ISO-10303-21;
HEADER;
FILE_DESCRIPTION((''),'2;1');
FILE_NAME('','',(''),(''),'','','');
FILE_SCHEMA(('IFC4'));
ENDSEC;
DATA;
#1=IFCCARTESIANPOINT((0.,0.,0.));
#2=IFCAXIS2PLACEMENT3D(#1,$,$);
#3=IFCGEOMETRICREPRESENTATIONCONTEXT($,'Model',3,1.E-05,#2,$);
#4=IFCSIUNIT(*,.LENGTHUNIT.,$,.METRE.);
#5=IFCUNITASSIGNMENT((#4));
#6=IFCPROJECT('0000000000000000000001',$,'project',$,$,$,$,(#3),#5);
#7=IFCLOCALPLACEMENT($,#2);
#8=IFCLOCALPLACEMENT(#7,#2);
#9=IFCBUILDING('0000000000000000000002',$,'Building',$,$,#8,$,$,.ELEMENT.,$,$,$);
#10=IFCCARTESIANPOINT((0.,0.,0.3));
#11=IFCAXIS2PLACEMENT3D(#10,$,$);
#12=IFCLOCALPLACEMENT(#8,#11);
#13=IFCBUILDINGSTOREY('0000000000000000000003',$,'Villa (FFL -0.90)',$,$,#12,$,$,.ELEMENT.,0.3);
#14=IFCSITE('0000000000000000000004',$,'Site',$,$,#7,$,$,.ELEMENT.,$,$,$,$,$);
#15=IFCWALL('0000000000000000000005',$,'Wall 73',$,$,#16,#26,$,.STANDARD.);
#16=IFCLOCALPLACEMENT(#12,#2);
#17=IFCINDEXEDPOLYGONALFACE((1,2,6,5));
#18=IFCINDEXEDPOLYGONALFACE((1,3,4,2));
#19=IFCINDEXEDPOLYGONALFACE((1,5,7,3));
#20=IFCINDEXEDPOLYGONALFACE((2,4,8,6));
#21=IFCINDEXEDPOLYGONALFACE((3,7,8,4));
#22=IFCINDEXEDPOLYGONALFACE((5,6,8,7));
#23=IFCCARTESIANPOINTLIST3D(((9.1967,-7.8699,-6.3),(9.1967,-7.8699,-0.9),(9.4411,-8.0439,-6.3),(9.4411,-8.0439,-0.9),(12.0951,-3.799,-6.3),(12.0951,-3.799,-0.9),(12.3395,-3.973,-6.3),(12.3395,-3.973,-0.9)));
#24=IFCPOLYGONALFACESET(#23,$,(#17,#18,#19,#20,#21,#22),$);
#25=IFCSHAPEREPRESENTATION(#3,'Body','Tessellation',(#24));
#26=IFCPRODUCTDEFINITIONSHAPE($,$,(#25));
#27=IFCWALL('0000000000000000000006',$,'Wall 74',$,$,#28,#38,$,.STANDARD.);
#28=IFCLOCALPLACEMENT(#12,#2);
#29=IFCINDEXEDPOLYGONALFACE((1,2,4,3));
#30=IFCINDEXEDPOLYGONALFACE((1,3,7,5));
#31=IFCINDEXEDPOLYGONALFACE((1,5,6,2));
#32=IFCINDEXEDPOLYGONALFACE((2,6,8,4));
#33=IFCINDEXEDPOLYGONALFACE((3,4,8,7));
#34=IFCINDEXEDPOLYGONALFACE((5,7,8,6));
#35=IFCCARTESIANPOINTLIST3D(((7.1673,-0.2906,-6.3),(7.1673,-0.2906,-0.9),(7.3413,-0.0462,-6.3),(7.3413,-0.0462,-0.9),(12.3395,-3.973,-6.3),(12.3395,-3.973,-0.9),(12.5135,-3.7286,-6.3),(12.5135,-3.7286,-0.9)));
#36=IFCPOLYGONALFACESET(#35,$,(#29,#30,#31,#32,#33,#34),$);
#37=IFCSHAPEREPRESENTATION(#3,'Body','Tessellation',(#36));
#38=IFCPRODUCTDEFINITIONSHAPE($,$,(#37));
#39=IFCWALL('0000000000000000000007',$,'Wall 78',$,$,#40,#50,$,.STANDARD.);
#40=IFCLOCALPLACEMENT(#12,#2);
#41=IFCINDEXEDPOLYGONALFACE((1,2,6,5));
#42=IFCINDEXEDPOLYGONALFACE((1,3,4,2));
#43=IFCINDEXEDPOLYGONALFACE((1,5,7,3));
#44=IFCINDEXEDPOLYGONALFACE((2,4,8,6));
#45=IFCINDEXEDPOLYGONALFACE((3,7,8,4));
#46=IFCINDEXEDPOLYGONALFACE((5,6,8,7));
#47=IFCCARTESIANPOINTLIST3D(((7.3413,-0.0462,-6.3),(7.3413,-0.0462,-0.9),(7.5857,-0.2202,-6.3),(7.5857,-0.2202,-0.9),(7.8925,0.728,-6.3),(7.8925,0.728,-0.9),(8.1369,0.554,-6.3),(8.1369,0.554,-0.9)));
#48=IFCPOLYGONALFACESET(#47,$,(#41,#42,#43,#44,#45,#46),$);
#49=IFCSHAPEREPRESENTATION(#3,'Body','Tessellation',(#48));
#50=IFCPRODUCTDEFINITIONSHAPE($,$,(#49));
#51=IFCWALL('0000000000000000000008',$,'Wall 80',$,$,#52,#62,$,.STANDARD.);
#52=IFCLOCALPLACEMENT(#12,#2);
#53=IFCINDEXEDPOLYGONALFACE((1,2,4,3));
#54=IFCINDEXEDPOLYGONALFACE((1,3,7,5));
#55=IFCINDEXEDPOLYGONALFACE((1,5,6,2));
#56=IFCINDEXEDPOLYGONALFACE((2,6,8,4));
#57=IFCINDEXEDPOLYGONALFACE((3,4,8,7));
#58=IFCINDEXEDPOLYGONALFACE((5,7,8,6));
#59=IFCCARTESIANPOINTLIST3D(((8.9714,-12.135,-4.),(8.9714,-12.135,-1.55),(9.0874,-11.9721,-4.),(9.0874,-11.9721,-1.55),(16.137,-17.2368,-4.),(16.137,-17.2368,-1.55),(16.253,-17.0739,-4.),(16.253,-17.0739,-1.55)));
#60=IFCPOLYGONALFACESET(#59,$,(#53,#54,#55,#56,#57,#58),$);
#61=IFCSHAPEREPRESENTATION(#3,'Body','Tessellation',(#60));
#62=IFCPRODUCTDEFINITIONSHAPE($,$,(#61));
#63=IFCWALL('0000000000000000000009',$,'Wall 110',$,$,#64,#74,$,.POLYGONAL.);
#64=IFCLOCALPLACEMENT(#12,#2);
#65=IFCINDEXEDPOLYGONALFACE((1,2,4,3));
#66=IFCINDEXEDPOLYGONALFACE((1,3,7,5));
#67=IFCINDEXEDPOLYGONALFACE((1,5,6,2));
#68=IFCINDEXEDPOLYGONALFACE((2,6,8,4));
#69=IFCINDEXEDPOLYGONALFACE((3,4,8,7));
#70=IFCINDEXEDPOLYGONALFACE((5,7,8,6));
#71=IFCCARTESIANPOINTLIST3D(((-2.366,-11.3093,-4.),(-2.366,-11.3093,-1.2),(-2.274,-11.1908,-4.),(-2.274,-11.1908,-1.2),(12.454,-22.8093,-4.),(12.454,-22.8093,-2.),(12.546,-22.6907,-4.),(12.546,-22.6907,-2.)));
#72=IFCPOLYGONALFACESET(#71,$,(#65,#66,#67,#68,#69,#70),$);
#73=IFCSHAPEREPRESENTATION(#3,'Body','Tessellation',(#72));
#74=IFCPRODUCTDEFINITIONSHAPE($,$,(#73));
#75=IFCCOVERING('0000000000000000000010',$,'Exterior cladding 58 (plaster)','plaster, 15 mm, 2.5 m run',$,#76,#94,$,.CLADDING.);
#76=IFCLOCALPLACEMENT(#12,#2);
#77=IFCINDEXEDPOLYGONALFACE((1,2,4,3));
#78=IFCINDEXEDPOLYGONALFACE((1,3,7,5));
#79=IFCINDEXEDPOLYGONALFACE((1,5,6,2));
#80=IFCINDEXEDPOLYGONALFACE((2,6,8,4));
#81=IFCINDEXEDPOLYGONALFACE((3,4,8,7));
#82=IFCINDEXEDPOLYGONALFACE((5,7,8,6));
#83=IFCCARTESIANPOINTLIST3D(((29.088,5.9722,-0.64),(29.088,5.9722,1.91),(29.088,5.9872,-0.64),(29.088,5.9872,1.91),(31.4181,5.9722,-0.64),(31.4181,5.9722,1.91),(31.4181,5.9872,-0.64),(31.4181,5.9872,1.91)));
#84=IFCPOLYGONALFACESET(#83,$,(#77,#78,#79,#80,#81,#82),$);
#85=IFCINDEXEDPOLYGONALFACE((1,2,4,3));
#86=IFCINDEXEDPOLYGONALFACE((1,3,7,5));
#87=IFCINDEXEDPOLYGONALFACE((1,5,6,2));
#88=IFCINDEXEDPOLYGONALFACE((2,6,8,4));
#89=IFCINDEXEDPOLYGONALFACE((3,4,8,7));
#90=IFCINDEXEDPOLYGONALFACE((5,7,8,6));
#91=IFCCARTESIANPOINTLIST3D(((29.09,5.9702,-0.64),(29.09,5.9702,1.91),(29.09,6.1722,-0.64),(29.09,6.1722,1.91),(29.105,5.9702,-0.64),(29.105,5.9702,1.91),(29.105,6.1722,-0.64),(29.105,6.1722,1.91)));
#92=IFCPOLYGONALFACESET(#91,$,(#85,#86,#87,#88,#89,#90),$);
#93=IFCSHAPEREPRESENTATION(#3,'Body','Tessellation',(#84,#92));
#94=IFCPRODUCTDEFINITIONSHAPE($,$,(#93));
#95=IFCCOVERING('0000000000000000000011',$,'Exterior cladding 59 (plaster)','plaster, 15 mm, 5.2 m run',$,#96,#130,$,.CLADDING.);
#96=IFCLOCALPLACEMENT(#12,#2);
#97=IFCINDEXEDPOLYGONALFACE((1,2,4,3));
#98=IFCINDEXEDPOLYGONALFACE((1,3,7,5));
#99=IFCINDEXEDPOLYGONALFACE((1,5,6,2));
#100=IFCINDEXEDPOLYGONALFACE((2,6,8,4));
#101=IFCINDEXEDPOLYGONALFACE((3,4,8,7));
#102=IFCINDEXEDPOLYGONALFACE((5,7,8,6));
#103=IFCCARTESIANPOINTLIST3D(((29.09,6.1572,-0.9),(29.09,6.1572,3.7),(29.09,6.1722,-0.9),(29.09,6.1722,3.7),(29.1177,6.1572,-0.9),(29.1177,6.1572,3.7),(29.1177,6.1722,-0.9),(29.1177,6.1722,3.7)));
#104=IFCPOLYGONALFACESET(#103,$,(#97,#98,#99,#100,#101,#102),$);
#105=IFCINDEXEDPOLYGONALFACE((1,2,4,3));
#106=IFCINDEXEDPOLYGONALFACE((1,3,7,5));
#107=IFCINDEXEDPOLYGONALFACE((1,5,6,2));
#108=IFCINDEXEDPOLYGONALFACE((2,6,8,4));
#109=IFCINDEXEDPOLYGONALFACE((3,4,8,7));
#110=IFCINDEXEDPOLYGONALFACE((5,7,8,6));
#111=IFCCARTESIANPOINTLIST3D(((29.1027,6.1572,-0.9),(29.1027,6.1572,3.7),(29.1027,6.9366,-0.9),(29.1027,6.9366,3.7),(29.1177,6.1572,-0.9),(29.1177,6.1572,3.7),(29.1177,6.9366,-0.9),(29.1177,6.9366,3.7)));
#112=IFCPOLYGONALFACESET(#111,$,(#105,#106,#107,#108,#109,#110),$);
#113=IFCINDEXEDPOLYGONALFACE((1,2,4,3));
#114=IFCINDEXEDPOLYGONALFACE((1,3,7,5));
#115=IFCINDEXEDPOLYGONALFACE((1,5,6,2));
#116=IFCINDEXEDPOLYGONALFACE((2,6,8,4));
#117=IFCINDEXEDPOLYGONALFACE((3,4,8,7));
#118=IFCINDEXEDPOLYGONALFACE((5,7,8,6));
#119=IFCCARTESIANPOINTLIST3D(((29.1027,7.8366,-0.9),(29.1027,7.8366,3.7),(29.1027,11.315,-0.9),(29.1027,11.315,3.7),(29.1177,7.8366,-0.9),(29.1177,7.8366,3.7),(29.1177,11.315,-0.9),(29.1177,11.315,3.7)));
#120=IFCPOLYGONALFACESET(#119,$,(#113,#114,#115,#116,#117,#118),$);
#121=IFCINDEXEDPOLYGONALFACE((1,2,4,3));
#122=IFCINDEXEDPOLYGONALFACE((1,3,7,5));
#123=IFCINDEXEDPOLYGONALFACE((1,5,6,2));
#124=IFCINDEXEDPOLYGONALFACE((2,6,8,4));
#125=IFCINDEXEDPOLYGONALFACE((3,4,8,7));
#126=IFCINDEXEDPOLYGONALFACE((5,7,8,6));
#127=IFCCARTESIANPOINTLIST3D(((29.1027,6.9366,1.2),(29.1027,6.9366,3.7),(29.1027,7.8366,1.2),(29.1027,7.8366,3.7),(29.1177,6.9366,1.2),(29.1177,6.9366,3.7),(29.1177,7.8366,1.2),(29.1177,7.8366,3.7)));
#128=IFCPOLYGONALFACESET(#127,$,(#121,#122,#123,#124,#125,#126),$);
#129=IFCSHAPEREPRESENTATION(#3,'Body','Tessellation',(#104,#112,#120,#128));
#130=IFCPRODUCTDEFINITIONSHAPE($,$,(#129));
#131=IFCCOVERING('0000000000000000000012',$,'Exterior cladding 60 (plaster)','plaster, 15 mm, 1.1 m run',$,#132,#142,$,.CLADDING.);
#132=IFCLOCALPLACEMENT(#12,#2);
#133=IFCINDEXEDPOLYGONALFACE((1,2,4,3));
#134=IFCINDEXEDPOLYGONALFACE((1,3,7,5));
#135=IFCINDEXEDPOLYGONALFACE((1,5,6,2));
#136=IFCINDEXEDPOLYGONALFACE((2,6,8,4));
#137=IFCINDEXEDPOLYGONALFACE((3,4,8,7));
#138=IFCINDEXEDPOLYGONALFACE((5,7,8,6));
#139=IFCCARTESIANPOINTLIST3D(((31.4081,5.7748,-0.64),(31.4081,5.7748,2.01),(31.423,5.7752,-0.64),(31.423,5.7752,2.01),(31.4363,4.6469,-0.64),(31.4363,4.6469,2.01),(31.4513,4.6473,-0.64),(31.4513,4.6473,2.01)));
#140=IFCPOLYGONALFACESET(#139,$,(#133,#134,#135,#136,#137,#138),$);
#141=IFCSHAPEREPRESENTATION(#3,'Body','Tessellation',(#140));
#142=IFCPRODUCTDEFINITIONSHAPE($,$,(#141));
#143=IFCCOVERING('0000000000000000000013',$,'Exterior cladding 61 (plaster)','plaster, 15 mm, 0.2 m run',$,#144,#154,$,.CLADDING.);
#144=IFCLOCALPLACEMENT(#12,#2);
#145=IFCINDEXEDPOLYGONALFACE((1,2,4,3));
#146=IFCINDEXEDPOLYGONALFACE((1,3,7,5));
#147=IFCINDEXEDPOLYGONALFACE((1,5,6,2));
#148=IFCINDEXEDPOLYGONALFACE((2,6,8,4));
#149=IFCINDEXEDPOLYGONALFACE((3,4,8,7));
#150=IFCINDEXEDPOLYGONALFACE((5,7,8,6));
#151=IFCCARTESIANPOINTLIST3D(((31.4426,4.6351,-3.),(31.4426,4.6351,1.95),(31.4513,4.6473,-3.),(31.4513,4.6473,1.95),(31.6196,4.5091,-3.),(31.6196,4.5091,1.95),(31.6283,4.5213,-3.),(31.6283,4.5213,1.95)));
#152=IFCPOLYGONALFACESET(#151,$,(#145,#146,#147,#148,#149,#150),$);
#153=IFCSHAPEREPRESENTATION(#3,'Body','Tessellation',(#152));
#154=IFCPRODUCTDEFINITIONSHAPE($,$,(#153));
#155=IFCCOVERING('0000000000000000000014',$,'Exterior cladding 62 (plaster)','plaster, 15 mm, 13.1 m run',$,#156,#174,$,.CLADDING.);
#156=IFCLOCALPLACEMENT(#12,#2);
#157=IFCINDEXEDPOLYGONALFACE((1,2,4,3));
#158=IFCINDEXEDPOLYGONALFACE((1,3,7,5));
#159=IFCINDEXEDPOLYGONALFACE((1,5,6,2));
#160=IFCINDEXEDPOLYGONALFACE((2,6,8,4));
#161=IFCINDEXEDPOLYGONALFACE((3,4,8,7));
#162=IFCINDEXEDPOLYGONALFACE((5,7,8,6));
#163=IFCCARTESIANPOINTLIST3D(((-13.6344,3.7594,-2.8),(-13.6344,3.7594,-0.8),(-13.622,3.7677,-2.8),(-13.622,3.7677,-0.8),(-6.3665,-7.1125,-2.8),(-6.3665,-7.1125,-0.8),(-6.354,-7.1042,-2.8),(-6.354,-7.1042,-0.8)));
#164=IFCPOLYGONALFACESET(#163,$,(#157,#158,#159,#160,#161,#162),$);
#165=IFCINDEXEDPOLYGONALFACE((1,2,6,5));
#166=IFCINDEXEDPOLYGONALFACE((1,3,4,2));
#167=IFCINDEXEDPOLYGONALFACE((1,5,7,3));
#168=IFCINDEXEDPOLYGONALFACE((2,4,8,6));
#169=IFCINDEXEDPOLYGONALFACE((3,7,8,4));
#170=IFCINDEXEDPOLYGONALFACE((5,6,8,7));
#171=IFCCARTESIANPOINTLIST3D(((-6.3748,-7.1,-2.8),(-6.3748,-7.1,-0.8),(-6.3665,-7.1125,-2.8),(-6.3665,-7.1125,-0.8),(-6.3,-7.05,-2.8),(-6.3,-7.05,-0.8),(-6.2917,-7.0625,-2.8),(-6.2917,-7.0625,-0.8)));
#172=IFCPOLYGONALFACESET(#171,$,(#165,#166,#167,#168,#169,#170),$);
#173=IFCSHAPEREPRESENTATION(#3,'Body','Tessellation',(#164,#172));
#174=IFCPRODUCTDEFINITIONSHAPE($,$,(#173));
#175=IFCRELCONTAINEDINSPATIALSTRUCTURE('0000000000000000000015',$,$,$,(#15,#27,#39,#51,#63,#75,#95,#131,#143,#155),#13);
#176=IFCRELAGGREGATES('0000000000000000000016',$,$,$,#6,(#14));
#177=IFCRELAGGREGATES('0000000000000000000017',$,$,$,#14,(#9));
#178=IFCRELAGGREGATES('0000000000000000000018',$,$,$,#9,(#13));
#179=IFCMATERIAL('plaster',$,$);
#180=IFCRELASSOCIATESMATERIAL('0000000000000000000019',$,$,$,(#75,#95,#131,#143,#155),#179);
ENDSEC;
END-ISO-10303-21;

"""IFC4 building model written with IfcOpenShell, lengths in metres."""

from ifc_helpers import new_model, si_unit, frame, frame_2d, origin, origin_with_axes, place, context, project, spatial, polyline, rectangle, outline, extrude, material, element, save


model = new_model("IFC4")

# Units and contexts
model_context = context("Model", 3, precision=1e-05, world=origin())
ifc_project = project(units=[si_unit("LENGTHUNIT", "METRE")], contexts=[model_context])

# Site, building, storey
site_placement = place(None, origin())
site = spatial("IfcSite", under=ifc_project, at=site_placement, Name="Site", CompositionType="ELEMENT")
building_placement = place(site_placement, origin())
building = spatial("IfcBuilding", under=site, at=building_placement, Name="Building", CompositionType="ELEMENT")
storey_placement = place(building_placement, frame((0.0, 0.0, 0.3)))
storey = spatial("IfcBuildingStorey", under=building, at=storey_placement, Name="Villa (FFL -0.90)", CompositionType="ELEMENT", Elevation=0.3)

# Walls
wall_1_placement = place(storey_placement, frame((9.3189, -7.9569, -6.3), z_axis=(0.0, 0.0, 1.0), x_axis=(0.579992, 0.814622, 0.0)))
element("IfcWall", 1, at=wall_1_placement, inside=storey, Name="Wall 73", PredefinedType="STANDARD", context=model_context, shape_type="SweptSolid", body=[
    extrude(rectangle(XDim=4.9973, YDim=0.3, at=frame_2d((2.4986, 0.0))), origin(), (0.0, 0.0, 1.0), 5.4),
])
wall_2_placement = place(storey_placement, frame((7.2543, -0.1684, -6.3), z_axis=(0.0, 0.0, 1.0), x_axis=(0.814622, -0.579992, 0.0)))
element("IfcWall", 2, at=wall_2_placement, inside=storey, Name="Wall 74", PredefinedType="STANDARD", context=model_context, shape_type="SweptSolid", body=[
    extrude(rectangle(XDim=6.3491, YDim=0.3, at=frame_2d((3.1746, 0.0))), origin(), (0.0, 0.0, 1.0), 5.4),
])
wall_3_placement = place(storey_placement, frame((7.4635, -0.1332, -6.3), z_axis=(0.0, 0.0, 1.0), x_axis=(0.579992, 0.814622, 0.0)))
element("IfcWall", 3, at=wall_3_placement, inside=storey, Name="Wall 78", PredefinedType="STANDARD", context=model_context, shape_type="SweptSolid", body=[
    extrude(rectangle(XDim=0.9503, YDim=0.3, at=frame_2d((0.4752, 0.0))), origin(), (0.0, 0.0, 1.0), 5.4),
])
wall_4_placement = place(storey_placement, frame((9.0294, -12.0536, -4.0), z_axis=(0.0, 0.0, 1.0), x_axis=(0.814622, -0.579992, 0.0)))
element("IfcWall", 4, at=wall_4_placement, inside=storey, Name="Wall 80", PredefinedType="STANDARD", context=model_context, shape_type="SweptSolid", body=[
    extrude(rectangle(XDim=8.7962, YDim=0.2, at=frame_2d((4.3981, 0.0))), origin(), (0.0, 0.0, 1.0), 2.45),
])
wall_5_placement = place(storey_placement, frame((12.5, -22.75, -4.0), z_axis=(0.0, 0.0, 1.0), x_axis=(-0.790041, 0.613054, 0.0)))
element("IfcWall", 5, at=wall_5_placement, inside=storey, Name="Wall 110", PredefinedType="POLYGONAL", context=model_context, shape_type="SweptSolid", body=[
    extrude(outline(polyline([(0.0, 0.0), (18.7585, 0.0), (18.7585, 2.8), (0.0, 2.0), (0.0, 0.0)])), frame((0.0, 0.075, 0.0), z_axis=(0.0, -1.0, 0.0), x_axis=(1.0, 0.0, 0.0)), (0.0, 0.0, 1.0), 0.15),
])

# Coverings
ifc_material = material(Name="plaster")
covering_1_placement = place(storey_placement, origin_with_axes())
element("IfcCovering", 6, at=covering_1_placement, inside=storey, material=ifc_material, Name="Exterior cladding 58 (plaster)", Description="plaster, 15 mm, 2.5 m run", PredefinedType="CLADDING", context=model_context, shape_type="SweptSolid", body=[
    extrude(outline(polyline([(31.4181, 5.9871), (29.088, 5.9871), (29.088, 5.9722), (31.4181, 5.9722), (31.4181, 5.9871)])), frame((0.0, 0.0, -0.64)), (0.0, 0.0, 1.0), 2.55),
    extrude(outline(polyline([(29.105, 5.9702), (29.105, 6.1722), (29.09, 6.1722), (29.09, 5.9702), (29.105, 5.9702)])), frame((0.0, 0.0, -0.64)), (0.0, 0.0, 1.0), 2.55),
])
covering_2_placement = place(storey_placement, origin_with_axes())
element("IfcCovering", 7, at=covering_2_placement, inside=storey, material=ifc_material, Name="Exterior cladding 59 (plaster)", Description="plaster, 15 mm, 5.2 m run", PredefinedType="CLADDING", context=model_context, shape_type="SweptSolid", body=[
    extrude(outline(polyline([(29.09, 6.1571), (29.1177, 6.1571), (29.1177, 6.1722), (29.09, 6.1722), (29.09, 6.1571)])), frame((0.0, 0.0, -0.9)), (0.0, 0.0, 1.0), 4.6),
    extrude(outline(polyline([(29.1177, 6.1571), (29.1177, 6.9366), (29.1027, 6.9366), (29.1027, 6.1571), (29.1177, 6.1571)])), frame((0.0, 0.0, -0.9)), (0.0, 0.0, 1.0), 4.6),
    extrude(outline(polyline([(29.1177, 7.8366), (29.1177, 11.315), (29.1027, 11.315), (29.1027, 7.8366), (29.1177, 7.8366)])), frame((0.0, 0.0, -0.9)), (0.0, 0.0, 1.0), 4.6),
    extrude(outline(polyline([(29.1177, 6.9366), (29.1177, 7.8366), (29.1027, 7.8366), (29.1027, 6.9366), (29.1177, 6.9366)])), frame((0.0, 0.0, 1.2)), (0.0, 0.0, 1.0), 2.5),
])
covering_3_placement = place(storey_placement, origin_with_axes())
element("IfcCovering", 8, at=covering_3_placement, inside=storey, material=ifc_material, Name="Exterior cladding 60 (plaster)", Description="plaster, 15 mm, 1.1 m run", PredefinedType="CLADDING", context=model_context, shape_type="SweptSolid", body=[
    extrude(outline(polyline([(31.4081, 5.7748), (31.4363, 4.6469), (31.4513, 4.6473), (31.423, 5.7752), (31.4081, 5.7748)])), frame((0.0, 0.0, -0.64)), (0.0, 0.0, 1.0), 2.65),
])
covering_4_placement = place(storey_placement, origin_with_axes())
element("IfcCovering", 9, at=covering_4_placement, inside=storey, material=ifc_material, Name="Exterior cladding 61 (plaster)", Description="plaster, 15 mm, 0.2 m run", PredefinedType="CLADDING", context=model_context, shape_type="SweptSolid", body=[
    extrude(outline(polyline([(31.4426, 4.6351), (31.6196, 4.5091), (31.6283, 4.5213), (31.4513, 4.6473), (31.4426, 4.6351)])), frame((0.0, 0.0, -3.0)), (0.0, 0.0, 1.0), 4.95),
])
covering_5_placement = place(storey_placement, origin_with_axes())
element("IfcCovering", 10, at=covering_5_placement, inside=storey, material=ifc_material, Name="Exterior cladding 62 (plaster)", Description="plaster, 15 mm, 13.1 m run", PredefinedType="CLADDING", context=model_context, shape_type="SweptSolid", body=[
    extrude(outline(polyline([(-13.6344, 3.7594), (-6.3665, -7.1125), (-6.354, -7.1041), (-13.622, 3.7677), (-13.6344, 3.7594)])), frame((0.0, 0.0, -2.8)), (0.0, 0.0, 1.0), 2.0),
    extrude(outline(polyline([(-6.3665, -7.1125), (-6.2917, -7.0625), (-6.3, -7.05), (-6.3748, -7.1), (-6.3665, -7.1125)])), frame((0.0, 0.0, -2.8)), (0.0, 0.0, 1.0), 2.0),
])

save(model, "model.ifc")
